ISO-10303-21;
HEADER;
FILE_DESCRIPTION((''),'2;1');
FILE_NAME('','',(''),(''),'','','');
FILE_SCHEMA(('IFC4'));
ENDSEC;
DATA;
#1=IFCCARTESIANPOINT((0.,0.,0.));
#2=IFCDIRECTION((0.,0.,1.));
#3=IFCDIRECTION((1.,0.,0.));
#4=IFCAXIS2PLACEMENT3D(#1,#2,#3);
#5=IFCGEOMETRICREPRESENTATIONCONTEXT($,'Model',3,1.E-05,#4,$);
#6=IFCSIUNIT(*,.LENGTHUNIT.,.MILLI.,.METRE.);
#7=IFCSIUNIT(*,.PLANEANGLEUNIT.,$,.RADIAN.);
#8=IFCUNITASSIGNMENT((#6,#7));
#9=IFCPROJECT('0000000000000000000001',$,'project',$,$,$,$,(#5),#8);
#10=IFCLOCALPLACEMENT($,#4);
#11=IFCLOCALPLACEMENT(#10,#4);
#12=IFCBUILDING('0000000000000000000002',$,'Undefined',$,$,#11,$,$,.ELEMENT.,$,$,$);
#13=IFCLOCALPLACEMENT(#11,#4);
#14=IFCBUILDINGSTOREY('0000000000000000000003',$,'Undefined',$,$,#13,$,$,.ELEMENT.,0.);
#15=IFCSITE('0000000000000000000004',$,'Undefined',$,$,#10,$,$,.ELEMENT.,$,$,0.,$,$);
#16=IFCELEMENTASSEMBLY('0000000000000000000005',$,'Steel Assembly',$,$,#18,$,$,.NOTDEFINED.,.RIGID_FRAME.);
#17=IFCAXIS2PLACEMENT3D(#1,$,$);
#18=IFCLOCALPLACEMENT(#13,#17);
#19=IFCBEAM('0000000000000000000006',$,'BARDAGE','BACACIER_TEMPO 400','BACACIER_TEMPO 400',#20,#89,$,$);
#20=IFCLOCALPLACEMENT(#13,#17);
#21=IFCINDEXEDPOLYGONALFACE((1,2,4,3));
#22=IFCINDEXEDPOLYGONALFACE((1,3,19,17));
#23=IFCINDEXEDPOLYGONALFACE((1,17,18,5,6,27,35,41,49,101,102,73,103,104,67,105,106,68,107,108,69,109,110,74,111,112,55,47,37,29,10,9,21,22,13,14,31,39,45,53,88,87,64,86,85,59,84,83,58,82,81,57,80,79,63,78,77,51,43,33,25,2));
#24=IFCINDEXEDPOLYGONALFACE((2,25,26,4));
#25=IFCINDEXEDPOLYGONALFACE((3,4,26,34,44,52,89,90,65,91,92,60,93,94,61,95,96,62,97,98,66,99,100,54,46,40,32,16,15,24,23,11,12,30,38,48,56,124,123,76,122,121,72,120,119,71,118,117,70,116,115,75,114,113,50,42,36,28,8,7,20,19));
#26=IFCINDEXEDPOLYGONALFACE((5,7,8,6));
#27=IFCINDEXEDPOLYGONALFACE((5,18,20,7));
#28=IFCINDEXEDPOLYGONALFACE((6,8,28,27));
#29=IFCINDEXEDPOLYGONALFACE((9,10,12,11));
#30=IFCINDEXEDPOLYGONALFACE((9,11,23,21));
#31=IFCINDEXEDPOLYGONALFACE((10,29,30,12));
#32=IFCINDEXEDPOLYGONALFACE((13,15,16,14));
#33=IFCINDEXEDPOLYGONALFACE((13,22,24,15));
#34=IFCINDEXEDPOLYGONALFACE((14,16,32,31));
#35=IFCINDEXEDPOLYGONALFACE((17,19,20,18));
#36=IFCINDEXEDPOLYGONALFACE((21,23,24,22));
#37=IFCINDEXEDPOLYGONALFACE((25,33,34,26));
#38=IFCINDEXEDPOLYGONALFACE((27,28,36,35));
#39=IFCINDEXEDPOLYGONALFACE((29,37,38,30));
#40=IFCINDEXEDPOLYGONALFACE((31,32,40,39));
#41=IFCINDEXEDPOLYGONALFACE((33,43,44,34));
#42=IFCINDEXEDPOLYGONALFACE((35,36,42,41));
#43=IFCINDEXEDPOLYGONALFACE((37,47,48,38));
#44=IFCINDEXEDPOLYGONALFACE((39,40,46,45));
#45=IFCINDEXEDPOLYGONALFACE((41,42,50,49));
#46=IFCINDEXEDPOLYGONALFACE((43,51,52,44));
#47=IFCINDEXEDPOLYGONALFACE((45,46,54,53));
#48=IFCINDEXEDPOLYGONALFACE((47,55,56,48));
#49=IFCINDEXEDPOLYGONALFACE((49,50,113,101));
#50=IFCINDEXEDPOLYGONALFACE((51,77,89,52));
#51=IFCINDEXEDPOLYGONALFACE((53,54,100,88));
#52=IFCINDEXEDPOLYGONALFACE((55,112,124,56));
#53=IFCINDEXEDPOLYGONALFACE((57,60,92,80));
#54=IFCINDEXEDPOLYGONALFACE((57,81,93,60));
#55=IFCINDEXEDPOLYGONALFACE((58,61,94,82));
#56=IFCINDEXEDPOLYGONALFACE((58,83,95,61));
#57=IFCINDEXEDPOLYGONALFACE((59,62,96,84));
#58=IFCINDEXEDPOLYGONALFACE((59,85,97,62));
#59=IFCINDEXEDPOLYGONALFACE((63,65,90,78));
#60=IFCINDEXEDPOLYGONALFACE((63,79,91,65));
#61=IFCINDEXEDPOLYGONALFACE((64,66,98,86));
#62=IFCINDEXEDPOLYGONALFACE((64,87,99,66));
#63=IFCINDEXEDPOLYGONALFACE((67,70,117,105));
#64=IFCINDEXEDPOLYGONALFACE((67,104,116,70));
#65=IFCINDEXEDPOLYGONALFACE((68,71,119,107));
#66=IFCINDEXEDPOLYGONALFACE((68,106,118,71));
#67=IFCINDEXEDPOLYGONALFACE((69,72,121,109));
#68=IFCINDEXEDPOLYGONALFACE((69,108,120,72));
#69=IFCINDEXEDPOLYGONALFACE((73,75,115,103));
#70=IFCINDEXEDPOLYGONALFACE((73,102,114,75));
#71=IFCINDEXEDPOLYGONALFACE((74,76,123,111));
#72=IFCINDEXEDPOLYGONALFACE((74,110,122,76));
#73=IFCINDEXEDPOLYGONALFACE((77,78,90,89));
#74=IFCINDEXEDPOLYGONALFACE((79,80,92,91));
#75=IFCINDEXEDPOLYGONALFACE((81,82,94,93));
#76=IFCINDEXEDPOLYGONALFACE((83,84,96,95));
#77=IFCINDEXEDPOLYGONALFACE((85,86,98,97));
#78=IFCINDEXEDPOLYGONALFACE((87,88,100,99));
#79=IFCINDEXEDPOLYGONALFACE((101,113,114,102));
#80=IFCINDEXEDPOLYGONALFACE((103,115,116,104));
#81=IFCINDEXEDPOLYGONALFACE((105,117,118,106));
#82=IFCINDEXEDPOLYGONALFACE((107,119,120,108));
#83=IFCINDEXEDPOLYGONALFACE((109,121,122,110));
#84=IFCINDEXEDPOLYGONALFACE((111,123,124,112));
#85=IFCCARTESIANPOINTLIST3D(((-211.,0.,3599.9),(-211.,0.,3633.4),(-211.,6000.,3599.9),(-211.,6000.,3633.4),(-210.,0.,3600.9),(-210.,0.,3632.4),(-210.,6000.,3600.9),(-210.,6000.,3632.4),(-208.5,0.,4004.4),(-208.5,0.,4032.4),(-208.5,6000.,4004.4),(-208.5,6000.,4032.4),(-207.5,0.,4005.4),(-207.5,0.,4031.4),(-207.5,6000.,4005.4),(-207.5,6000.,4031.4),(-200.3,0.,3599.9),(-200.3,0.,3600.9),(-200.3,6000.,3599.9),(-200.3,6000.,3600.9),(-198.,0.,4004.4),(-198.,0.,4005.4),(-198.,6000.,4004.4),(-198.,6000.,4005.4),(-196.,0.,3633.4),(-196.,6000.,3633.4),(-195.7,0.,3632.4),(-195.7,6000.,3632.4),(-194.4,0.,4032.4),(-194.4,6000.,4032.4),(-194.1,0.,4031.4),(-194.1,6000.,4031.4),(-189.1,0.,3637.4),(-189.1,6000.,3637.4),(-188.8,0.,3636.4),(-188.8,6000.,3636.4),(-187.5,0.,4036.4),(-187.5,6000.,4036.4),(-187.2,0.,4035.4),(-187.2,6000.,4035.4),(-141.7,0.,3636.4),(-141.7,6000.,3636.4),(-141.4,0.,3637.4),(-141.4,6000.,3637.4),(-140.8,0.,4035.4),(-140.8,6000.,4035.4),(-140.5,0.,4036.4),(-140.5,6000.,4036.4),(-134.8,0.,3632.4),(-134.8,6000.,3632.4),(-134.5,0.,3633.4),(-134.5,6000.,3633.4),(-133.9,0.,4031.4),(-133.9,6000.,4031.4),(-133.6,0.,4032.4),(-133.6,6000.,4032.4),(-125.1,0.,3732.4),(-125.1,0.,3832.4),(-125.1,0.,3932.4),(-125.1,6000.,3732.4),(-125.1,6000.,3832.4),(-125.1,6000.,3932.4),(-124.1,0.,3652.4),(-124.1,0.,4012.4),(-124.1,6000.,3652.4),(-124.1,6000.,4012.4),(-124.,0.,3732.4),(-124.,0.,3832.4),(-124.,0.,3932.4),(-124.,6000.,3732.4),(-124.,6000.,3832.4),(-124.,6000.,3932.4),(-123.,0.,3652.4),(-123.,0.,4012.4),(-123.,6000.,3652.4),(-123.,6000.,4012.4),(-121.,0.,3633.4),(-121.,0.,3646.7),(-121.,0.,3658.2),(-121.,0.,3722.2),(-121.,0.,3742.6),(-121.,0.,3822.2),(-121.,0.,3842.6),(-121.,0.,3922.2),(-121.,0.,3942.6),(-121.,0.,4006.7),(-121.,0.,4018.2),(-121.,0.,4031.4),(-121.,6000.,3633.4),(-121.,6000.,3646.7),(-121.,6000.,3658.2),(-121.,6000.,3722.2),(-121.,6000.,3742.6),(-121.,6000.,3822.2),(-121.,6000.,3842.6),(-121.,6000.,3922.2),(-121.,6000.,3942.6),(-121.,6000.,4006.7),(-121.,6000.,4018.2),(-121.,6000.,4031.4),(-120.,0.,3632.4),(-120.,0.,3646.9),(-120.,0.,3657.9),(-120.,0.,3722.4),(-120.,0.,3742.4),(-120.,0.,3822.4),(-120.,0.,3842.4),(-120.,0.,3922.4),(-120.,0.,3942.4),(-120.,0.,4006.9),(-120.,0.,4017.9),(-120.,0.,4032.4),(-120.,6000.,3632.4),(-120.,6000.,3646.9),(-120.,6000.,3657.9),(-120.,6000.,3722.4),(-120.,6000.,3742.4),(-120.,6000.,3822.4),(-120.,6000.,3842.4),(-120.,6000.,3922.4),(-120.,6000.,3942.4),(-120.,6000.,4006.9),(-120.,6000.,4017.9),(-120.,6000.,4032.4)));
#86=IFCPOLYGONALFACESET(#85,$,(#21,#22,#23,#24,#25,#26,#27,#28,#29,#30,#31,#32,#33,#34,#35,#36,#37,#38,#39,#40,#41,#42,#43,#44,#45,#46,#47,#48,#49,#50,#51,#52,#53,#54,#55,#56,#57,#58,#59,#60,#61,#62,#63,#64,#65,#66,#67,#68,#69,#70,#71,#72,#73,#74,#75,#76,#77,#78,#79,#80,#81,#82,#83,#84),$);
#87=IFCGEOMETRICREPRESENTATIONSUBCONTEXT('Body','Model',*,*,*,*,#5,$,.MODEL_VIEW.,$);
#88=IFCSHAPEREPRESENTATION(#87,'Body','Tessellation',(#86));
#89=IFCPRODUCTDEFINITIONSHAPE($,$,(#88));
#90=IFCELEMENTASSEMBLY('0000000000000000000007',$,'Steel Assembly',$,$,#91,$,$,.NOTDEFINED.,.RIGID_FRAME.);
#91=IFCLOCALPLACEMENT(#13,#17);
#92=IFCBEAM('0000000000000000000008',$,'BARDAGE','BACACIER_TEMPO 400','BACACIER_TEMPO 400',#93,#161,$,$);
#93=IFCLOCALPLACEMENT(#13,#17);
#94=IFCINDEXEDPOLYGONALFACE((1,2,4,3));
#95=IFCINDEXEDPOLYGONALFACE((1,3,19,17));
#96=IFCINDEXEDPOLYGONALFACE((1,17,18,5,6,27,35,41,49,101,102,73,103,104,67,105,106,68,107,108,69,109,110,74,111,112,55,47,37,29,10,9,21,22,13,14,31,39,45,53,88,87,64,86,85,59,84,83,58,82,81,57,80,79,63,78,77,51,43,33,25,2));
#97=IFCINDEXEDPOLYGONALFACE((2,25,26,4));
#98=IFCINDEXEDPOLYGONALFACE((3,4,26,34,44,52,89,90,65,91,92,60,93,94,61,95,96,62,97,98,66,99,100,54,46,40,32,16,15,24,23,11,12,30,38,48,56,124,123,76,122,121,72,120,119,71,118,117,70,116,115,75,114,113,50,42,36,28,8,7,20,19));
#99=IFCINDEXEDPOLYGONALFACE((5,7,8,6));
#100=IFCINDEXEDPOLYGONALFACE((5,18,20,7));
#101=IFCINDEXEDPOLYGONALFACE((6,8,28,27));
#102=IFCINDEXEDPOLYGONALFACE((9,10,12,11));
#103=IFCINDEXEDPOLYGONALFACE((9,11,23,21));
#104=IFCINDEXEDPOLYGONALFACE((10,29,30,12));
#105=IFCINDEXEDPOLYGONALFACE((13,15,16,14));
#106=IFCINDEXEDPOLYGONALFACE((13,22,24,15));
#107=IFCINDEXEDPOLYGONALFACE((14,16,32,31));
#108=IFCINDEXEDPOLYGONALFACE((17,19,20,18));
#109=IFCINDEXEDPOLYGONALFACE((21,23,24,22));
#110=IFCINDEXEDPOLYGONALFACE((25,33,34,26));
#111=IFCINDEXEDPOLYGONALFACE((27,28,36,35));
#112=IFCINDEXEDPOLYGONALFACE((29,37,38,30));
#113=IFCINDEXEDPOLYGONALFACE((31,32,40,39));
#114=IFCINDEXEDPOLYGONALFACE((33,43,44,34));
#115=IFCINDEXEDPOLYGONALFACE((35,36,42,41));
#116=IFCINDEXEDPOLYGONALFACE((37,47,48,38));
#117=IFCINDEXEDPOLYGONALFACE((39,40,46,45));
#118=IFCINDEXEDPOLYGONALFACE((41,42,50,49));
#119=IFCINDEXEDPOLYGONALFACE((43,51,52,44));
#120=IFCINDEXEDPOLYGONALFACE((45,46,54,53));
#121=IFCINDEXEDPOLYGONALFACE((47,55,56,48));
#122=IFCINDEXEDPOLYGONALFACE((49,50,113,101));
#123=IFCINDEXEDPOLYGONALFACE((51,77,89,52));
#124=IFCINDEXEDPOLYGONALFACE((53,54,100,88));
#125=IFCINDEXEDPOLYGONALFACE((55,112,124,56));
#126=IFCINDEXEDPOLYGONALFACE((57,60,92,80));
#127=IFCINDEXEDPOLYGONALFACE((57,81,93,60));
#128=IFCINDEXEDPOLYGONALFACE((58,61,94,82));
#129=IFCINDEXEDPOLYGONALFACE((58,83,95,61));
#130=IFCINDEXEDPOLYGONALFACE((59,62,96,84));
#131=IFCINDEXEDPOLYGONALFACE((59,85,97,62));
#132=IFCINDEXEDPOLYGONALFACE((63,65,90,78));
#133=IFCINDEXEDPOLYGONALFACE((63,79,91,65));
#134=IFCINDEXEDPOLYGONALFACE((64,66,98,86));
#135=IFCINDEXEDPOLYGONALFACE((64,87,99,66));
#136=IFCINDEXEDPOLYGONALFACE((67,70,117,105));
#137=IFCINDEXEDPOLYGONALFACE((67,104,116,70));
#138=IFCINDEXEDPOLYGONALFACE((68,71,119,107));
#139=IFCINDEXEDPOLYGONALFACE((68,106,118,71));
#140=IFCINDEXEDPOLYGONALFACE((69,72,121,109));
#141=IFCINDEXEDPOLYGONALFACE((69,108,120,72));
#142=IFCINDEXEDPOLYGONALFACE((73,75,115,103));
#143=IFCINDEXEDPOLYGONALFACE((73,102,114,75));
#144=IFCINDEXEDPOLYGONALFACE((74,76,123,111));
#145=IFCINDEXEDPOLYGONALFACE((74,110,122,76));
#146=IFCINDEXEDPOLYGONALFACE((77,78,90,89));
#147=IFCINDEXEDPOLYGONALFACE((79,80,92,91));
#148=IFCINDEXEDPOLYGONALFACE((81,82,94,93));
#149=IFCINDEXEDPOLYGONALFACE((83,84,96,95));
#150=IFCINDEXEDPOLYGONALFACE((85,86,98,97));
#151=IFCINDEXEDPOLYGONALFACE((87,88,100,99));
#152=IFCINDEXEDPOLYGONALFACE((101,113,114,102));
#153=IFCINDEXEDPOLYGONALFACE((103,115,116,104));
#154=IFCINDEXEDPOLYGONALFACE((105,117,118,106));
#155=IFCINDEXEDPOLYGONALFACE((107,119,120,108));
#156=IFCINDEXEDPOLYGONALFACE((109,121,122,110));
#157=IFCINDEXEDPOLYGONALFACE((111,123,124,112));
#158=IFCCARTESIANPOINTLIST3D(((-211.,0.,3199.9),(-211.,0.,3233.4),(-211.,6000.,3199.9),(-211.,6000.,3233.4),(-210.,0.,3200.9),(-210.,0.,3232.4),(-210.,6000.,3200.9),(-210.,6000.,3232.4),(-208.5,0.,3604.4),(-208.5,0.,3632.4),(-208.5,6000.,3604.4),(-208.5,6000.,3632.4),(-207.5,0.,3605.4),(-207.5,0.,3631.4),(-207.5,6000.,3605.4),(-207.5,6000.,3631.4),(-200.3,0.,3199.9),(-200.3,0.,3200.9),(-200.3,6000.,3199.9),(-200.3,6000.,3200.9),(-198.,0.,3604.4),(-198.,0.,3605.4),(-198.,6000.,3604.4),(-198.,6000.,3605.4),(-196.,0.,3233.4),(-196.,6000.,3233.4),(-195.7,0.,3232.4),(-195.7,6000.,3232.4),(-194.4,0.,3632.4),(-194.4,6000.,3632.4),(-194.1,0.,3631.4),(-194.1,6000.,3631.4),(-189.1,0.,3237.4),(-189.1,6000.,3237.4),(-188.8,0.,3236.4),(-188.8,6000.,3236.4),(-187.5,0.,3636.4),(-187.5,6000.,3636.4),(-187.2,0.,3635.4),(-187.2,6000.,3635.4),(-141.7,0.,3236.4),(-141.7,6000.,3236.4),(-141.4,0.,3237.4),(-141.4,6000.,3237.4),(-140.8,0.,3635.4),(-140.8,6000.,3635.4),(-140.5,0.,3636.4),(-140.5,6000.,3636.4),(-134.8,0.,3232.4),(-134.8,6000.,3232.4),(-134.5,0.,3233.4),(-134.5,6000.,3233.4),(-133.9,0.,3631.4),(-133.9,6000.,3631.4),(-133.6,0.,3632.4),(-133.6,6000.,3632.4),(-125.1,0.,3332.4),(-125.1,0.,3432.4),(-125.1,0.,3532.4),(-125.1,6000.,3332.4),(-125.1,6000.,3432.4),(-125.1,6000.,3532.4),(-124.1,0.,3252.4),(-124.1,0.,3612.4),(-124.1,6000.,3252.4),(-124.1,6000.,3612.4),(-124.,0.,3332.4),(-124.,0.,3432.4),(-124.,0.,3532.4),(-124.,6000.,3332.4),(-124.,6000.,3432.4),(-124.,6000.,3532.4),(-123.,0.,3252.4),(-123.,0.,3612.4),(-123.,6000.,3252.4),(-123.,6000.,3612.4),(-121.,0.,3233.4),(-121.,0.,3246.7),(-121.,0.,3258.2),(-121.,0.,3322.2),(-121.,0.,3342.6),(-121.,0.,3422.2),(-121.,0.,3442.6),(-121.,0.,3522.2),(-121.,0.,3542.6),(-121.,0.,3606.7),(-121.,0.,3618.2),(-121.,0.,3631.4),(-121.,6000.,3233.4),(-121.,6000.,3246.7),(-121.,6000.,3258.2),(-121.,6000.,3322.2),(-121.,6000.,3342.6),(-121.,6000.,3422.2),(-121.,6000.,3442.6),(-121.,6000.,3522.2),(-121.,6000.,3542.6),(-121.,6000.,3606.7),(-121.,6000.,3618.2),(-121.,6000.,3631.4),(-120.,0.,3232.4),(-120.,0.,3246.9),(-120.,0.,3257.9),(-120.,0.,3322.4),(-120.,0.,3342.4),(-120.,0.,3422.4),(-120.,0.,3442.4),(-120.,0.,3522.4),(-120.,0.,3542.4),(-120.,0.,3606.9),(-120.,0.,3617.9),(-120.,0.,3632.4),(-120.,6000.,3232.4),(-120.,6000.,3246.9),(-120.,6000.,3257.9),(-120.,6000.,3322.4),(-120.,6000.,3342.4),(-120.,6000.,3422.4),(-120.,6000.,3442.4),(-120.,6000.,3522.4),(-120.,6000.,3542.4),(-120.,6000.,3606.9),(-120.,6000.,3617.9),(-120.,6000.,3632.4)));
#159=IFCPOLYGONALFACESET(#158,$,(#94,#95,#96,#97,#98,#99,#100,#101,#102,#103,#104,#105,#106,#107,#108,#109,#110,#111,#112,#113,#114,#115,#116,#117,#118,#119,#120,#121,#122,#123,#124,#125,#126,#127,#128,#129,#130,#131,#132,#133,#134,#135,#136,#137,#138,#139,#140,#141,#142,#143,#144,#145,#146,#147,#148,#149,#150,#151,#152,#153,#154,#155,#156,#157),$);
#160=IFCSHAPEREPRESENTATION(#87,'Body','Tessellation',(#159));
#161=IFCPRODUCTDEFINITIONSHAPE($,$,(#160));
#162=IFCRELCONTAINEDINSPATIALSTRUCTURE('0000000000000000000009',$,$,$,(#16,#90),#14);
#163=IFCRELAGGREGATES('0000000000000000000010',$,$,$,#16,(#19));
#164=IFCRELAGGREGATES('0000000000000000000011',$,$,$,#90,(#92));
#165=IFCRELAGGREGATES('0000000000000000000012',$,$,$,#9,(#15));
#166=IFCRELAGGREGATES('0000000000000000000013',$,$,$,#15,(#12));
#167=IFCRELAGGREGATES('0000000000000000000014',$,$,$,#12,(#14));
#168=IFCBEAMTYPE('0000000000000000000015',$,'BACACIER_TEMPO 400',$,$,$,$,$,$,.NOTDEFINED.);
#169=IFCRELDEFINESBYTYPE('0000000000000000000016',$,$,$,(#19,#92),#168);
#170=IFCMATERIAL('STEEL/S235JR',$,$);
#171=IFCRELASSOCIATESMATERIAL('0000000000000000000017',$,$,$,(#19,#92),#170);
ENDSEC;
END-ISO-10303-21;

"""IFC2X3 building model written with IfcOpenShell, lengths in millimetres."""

from ifc_helpers import new_model, si_unit, frame, origin_with_axes, place, context, subcontext, project, spatial, polyline, outline, extrude, material, type_object, element, aggregate, save


model = new_model("IFC2X3")

# Units and contexts
model_context = context("Model", 3, precision=1e-05, world=origin_with_axes())
body_context = subcontext(model_context, "Body", "Model", "MODEL_VIEW")
ifc_project = project(units=[si_unit("LENGTHUNIT", "METRE", prefix="MILLI"), si_unit("PLANEANGLEUNIT", "RADIAN")], contexts=[model_context])

# Site, building, storey
site_placement = place(None, origin_with_axes())
site = spatial("IfcSite", under=ifc_project, at=site_placement, Name="Undefined", CompositionType="ELEMENT", RefElevation=0.0)
building_placement = place(site_placement, origin_with_axes())
building = spatial("IfcBuilding", under=site, at=building_placement, Name="Undefined", CompositionType="ELEMENT")
storey_placement = place(building_placement, origin_with_axes())
storey = spatial("IfcBuildingStorey", under=building, at=storey_placement, Name="Undefined", CompositionType="ELEMENT", Elevation=0.0)

# Element assemblies, beams
ifc_material_1 = material(Name="STEEL/S235JR")
beam_type_1 = type_object("IfcBeamType", Name="BACACIER_TEMPO 400", PredefinedType="NOTDEFINED")
assembly_1_placement = place(storey_placement, origin_with_axes())
assembly_1 = element("IfcElementAssembly", 1, at=assembly_1_placement, inside=storey, Name="Steel Assembly", AssemblyPlace="NOTDEFINED", PredefinedType="RIGID_FRAME")
beam_1_placement = place(assembly_1_placement, frame((-165.5, 0.0, 3818.2), z_axis=(-1.0, 0.0, 0.0), x_axis=(0.0, 1.0, 0.0)))
beam_1 = element("IfcBeam", 2, at=beam_1_placement, type_object=beam_type_1, material=ifc_material_1, Name="BARDAGE", Description="BACACIER_TEMPO 400", ObjectType="BACACIER_TEMPO 400", context=body_context, shape_type="SweptSolid", body=[
    extrude(outline(polyline([(218.2, -25.0), (214.2, -31.9), (214.2, -45.5), (199.8, -45.5), (194.2, -42.5), (188.8, -45.5), (124.2, -45.5), (114.2, -41.5), (104.2, -45.5), (24.2, -45.5), (14.2, -41.5), (4.2, -45.5), (-75.8, -45.5), (-85.8, -41.5), (-95.8, -45.5), (-160.2, -45.5), (-165.8, -42.5), (-171.2, -45.5), (-185.8, -45.5), (-185.8, -30.7), (-181.8, -23.8), (-181.8, 23.3), (-185.8, 30.2), (-185.8, 44.5), (-217.2, 44.5), (-217.2, 34.8), (-218.2, 34.8), (-218.2, 45.5), (-184.8, 45.5), (-184.8, 30.5), (-180.8, 23.6), (-180.8, -24.1), (-184.8, -31.0), (-184.8, -44.5), (-171.5, -44.5), (-165.8, -41.4), (-160.0, -44.5), (-95.9, -44.5), (-85.8, -40.4), (-75.6, -44.5), (4.1, -44.5), (14.2, -40.4), (24.4, -44.5), (104.1, -44.5), (114.2, -40.4), (124.4, -44.5), (188.5, -44.5), (194.2, -41.4), (200.0, -44.5), (213.2, -44.5), (213.2, -31.6), (217.2, -24.7), (217.2, 21.7), (213.2, 28.6), (213.2, 42.0), (187.2, 42.0), (187.2, 32.5), (186.2, 32.5), (186.2, 43.0), (214.2, 43.0), (214.2, 28.9), (218.2, 22.0), (218.2, -25.0)])), frame((6000.0, 0.0, 0.0), z_axis=(-1.0, 0.0, 0.0), x_axis=(0.0, -1.0, 0.0)), (0.0, 0.0, 1.0), 6000.0),
])
aggregate(assembly_1, [beam_1])
assembly_2_placement = place(storey_placement, origin_with_axes())
assembly_2 = element("IfcElementAssembly", 3, at=assembly_2_placement, inside=storey, Name="Steel Assembly", AssemblyPlace="NOTDEFINED", PredefinedType="RIGID_FRAME")
beam_2_placement = place(assembly_2_placement, frame((-165.5, 0.0, 3418.2), z_axis=(-1.0, 0.0, 0.0), x_axis=(0.0, 1.0, 0.0)))
beam_2 = element("IfcBeam", 4, at=beam_2_placement, type_object=beam_type_1, material=ifc_material_1, Name="BARDAGE", Description="BACACIER_TEMPO 400", ObjectType="BACACIER_TEMPO 400", context=body_context, shape_type="SweptSolid", body=[
    extrude(outline(polyline([(218.2, -25.0), (214.2, -31.9), (214.2, -45.5), (199.8, -45.5), (194.2, -42.5), (188.8, -45.5), (124.2, -45.5), (114.2, -41.5), (104.2, -45.5), (24.2, -45.5), (14.2, -41.5), (4.2, -45.5), (-75.8, -45.5), (-85.8, -41.5), (-95.8, -45.5), (-160.2, -45.5), (-165.8, -42.5), (-171.2, -45.5), (-185.8, -45.5), (-185.8, -30.7), (-181.8, -23.8), (-181.8, 23.3), (-185.8, 30.2), (-185.8, 44.5), (-217.2, 44.5), (-217.2, 34.8), (-218.2, 34.8), (-218.2, 45.5), (-184.8, 45.5), (-184.8, 30.5), (-180.8, 23.6), (-180.8, -24.1), (-184.8, -31.0), (-184.8, -44.5), (-171.5, -44.5), (-165.8, -41.4), (-160.0, -44.5), (-95.9, -44.5), (-85.8, -40.4), (-75.6, -44.5), (4.1, -44.5), (14.2, -40.4), (24.4, -44.5), (104.1, -44.5), (114.2, -40.4), (124.4, -44.5), (188.5, -44.5), (194.2, -41.4), (200.0, -44.5), (213.2, -44.5), (213.2, -31.6), (217.2, -24.7), (217.2, 21.7), (213.2, 28.6), (213.2, 42.0), (187.2, 42.0), (187.2, 32.5), (186.2, 32.5), (186.2, 43.0), (214.2, 43.0), (214.2, 28.9), (218.2, 22.0), (218.2, -25.0)])), frame((6000.0, 0.0, 0.0), z_axis=(-1.0, 0.0, 0.0), x_axis=(0.0, -1.0, 0.0)), (0.0, 0.0, 1.0), 6000.0),
])
aggregate(assembly_2, [beam_2])

save(model, "model.ifc")
